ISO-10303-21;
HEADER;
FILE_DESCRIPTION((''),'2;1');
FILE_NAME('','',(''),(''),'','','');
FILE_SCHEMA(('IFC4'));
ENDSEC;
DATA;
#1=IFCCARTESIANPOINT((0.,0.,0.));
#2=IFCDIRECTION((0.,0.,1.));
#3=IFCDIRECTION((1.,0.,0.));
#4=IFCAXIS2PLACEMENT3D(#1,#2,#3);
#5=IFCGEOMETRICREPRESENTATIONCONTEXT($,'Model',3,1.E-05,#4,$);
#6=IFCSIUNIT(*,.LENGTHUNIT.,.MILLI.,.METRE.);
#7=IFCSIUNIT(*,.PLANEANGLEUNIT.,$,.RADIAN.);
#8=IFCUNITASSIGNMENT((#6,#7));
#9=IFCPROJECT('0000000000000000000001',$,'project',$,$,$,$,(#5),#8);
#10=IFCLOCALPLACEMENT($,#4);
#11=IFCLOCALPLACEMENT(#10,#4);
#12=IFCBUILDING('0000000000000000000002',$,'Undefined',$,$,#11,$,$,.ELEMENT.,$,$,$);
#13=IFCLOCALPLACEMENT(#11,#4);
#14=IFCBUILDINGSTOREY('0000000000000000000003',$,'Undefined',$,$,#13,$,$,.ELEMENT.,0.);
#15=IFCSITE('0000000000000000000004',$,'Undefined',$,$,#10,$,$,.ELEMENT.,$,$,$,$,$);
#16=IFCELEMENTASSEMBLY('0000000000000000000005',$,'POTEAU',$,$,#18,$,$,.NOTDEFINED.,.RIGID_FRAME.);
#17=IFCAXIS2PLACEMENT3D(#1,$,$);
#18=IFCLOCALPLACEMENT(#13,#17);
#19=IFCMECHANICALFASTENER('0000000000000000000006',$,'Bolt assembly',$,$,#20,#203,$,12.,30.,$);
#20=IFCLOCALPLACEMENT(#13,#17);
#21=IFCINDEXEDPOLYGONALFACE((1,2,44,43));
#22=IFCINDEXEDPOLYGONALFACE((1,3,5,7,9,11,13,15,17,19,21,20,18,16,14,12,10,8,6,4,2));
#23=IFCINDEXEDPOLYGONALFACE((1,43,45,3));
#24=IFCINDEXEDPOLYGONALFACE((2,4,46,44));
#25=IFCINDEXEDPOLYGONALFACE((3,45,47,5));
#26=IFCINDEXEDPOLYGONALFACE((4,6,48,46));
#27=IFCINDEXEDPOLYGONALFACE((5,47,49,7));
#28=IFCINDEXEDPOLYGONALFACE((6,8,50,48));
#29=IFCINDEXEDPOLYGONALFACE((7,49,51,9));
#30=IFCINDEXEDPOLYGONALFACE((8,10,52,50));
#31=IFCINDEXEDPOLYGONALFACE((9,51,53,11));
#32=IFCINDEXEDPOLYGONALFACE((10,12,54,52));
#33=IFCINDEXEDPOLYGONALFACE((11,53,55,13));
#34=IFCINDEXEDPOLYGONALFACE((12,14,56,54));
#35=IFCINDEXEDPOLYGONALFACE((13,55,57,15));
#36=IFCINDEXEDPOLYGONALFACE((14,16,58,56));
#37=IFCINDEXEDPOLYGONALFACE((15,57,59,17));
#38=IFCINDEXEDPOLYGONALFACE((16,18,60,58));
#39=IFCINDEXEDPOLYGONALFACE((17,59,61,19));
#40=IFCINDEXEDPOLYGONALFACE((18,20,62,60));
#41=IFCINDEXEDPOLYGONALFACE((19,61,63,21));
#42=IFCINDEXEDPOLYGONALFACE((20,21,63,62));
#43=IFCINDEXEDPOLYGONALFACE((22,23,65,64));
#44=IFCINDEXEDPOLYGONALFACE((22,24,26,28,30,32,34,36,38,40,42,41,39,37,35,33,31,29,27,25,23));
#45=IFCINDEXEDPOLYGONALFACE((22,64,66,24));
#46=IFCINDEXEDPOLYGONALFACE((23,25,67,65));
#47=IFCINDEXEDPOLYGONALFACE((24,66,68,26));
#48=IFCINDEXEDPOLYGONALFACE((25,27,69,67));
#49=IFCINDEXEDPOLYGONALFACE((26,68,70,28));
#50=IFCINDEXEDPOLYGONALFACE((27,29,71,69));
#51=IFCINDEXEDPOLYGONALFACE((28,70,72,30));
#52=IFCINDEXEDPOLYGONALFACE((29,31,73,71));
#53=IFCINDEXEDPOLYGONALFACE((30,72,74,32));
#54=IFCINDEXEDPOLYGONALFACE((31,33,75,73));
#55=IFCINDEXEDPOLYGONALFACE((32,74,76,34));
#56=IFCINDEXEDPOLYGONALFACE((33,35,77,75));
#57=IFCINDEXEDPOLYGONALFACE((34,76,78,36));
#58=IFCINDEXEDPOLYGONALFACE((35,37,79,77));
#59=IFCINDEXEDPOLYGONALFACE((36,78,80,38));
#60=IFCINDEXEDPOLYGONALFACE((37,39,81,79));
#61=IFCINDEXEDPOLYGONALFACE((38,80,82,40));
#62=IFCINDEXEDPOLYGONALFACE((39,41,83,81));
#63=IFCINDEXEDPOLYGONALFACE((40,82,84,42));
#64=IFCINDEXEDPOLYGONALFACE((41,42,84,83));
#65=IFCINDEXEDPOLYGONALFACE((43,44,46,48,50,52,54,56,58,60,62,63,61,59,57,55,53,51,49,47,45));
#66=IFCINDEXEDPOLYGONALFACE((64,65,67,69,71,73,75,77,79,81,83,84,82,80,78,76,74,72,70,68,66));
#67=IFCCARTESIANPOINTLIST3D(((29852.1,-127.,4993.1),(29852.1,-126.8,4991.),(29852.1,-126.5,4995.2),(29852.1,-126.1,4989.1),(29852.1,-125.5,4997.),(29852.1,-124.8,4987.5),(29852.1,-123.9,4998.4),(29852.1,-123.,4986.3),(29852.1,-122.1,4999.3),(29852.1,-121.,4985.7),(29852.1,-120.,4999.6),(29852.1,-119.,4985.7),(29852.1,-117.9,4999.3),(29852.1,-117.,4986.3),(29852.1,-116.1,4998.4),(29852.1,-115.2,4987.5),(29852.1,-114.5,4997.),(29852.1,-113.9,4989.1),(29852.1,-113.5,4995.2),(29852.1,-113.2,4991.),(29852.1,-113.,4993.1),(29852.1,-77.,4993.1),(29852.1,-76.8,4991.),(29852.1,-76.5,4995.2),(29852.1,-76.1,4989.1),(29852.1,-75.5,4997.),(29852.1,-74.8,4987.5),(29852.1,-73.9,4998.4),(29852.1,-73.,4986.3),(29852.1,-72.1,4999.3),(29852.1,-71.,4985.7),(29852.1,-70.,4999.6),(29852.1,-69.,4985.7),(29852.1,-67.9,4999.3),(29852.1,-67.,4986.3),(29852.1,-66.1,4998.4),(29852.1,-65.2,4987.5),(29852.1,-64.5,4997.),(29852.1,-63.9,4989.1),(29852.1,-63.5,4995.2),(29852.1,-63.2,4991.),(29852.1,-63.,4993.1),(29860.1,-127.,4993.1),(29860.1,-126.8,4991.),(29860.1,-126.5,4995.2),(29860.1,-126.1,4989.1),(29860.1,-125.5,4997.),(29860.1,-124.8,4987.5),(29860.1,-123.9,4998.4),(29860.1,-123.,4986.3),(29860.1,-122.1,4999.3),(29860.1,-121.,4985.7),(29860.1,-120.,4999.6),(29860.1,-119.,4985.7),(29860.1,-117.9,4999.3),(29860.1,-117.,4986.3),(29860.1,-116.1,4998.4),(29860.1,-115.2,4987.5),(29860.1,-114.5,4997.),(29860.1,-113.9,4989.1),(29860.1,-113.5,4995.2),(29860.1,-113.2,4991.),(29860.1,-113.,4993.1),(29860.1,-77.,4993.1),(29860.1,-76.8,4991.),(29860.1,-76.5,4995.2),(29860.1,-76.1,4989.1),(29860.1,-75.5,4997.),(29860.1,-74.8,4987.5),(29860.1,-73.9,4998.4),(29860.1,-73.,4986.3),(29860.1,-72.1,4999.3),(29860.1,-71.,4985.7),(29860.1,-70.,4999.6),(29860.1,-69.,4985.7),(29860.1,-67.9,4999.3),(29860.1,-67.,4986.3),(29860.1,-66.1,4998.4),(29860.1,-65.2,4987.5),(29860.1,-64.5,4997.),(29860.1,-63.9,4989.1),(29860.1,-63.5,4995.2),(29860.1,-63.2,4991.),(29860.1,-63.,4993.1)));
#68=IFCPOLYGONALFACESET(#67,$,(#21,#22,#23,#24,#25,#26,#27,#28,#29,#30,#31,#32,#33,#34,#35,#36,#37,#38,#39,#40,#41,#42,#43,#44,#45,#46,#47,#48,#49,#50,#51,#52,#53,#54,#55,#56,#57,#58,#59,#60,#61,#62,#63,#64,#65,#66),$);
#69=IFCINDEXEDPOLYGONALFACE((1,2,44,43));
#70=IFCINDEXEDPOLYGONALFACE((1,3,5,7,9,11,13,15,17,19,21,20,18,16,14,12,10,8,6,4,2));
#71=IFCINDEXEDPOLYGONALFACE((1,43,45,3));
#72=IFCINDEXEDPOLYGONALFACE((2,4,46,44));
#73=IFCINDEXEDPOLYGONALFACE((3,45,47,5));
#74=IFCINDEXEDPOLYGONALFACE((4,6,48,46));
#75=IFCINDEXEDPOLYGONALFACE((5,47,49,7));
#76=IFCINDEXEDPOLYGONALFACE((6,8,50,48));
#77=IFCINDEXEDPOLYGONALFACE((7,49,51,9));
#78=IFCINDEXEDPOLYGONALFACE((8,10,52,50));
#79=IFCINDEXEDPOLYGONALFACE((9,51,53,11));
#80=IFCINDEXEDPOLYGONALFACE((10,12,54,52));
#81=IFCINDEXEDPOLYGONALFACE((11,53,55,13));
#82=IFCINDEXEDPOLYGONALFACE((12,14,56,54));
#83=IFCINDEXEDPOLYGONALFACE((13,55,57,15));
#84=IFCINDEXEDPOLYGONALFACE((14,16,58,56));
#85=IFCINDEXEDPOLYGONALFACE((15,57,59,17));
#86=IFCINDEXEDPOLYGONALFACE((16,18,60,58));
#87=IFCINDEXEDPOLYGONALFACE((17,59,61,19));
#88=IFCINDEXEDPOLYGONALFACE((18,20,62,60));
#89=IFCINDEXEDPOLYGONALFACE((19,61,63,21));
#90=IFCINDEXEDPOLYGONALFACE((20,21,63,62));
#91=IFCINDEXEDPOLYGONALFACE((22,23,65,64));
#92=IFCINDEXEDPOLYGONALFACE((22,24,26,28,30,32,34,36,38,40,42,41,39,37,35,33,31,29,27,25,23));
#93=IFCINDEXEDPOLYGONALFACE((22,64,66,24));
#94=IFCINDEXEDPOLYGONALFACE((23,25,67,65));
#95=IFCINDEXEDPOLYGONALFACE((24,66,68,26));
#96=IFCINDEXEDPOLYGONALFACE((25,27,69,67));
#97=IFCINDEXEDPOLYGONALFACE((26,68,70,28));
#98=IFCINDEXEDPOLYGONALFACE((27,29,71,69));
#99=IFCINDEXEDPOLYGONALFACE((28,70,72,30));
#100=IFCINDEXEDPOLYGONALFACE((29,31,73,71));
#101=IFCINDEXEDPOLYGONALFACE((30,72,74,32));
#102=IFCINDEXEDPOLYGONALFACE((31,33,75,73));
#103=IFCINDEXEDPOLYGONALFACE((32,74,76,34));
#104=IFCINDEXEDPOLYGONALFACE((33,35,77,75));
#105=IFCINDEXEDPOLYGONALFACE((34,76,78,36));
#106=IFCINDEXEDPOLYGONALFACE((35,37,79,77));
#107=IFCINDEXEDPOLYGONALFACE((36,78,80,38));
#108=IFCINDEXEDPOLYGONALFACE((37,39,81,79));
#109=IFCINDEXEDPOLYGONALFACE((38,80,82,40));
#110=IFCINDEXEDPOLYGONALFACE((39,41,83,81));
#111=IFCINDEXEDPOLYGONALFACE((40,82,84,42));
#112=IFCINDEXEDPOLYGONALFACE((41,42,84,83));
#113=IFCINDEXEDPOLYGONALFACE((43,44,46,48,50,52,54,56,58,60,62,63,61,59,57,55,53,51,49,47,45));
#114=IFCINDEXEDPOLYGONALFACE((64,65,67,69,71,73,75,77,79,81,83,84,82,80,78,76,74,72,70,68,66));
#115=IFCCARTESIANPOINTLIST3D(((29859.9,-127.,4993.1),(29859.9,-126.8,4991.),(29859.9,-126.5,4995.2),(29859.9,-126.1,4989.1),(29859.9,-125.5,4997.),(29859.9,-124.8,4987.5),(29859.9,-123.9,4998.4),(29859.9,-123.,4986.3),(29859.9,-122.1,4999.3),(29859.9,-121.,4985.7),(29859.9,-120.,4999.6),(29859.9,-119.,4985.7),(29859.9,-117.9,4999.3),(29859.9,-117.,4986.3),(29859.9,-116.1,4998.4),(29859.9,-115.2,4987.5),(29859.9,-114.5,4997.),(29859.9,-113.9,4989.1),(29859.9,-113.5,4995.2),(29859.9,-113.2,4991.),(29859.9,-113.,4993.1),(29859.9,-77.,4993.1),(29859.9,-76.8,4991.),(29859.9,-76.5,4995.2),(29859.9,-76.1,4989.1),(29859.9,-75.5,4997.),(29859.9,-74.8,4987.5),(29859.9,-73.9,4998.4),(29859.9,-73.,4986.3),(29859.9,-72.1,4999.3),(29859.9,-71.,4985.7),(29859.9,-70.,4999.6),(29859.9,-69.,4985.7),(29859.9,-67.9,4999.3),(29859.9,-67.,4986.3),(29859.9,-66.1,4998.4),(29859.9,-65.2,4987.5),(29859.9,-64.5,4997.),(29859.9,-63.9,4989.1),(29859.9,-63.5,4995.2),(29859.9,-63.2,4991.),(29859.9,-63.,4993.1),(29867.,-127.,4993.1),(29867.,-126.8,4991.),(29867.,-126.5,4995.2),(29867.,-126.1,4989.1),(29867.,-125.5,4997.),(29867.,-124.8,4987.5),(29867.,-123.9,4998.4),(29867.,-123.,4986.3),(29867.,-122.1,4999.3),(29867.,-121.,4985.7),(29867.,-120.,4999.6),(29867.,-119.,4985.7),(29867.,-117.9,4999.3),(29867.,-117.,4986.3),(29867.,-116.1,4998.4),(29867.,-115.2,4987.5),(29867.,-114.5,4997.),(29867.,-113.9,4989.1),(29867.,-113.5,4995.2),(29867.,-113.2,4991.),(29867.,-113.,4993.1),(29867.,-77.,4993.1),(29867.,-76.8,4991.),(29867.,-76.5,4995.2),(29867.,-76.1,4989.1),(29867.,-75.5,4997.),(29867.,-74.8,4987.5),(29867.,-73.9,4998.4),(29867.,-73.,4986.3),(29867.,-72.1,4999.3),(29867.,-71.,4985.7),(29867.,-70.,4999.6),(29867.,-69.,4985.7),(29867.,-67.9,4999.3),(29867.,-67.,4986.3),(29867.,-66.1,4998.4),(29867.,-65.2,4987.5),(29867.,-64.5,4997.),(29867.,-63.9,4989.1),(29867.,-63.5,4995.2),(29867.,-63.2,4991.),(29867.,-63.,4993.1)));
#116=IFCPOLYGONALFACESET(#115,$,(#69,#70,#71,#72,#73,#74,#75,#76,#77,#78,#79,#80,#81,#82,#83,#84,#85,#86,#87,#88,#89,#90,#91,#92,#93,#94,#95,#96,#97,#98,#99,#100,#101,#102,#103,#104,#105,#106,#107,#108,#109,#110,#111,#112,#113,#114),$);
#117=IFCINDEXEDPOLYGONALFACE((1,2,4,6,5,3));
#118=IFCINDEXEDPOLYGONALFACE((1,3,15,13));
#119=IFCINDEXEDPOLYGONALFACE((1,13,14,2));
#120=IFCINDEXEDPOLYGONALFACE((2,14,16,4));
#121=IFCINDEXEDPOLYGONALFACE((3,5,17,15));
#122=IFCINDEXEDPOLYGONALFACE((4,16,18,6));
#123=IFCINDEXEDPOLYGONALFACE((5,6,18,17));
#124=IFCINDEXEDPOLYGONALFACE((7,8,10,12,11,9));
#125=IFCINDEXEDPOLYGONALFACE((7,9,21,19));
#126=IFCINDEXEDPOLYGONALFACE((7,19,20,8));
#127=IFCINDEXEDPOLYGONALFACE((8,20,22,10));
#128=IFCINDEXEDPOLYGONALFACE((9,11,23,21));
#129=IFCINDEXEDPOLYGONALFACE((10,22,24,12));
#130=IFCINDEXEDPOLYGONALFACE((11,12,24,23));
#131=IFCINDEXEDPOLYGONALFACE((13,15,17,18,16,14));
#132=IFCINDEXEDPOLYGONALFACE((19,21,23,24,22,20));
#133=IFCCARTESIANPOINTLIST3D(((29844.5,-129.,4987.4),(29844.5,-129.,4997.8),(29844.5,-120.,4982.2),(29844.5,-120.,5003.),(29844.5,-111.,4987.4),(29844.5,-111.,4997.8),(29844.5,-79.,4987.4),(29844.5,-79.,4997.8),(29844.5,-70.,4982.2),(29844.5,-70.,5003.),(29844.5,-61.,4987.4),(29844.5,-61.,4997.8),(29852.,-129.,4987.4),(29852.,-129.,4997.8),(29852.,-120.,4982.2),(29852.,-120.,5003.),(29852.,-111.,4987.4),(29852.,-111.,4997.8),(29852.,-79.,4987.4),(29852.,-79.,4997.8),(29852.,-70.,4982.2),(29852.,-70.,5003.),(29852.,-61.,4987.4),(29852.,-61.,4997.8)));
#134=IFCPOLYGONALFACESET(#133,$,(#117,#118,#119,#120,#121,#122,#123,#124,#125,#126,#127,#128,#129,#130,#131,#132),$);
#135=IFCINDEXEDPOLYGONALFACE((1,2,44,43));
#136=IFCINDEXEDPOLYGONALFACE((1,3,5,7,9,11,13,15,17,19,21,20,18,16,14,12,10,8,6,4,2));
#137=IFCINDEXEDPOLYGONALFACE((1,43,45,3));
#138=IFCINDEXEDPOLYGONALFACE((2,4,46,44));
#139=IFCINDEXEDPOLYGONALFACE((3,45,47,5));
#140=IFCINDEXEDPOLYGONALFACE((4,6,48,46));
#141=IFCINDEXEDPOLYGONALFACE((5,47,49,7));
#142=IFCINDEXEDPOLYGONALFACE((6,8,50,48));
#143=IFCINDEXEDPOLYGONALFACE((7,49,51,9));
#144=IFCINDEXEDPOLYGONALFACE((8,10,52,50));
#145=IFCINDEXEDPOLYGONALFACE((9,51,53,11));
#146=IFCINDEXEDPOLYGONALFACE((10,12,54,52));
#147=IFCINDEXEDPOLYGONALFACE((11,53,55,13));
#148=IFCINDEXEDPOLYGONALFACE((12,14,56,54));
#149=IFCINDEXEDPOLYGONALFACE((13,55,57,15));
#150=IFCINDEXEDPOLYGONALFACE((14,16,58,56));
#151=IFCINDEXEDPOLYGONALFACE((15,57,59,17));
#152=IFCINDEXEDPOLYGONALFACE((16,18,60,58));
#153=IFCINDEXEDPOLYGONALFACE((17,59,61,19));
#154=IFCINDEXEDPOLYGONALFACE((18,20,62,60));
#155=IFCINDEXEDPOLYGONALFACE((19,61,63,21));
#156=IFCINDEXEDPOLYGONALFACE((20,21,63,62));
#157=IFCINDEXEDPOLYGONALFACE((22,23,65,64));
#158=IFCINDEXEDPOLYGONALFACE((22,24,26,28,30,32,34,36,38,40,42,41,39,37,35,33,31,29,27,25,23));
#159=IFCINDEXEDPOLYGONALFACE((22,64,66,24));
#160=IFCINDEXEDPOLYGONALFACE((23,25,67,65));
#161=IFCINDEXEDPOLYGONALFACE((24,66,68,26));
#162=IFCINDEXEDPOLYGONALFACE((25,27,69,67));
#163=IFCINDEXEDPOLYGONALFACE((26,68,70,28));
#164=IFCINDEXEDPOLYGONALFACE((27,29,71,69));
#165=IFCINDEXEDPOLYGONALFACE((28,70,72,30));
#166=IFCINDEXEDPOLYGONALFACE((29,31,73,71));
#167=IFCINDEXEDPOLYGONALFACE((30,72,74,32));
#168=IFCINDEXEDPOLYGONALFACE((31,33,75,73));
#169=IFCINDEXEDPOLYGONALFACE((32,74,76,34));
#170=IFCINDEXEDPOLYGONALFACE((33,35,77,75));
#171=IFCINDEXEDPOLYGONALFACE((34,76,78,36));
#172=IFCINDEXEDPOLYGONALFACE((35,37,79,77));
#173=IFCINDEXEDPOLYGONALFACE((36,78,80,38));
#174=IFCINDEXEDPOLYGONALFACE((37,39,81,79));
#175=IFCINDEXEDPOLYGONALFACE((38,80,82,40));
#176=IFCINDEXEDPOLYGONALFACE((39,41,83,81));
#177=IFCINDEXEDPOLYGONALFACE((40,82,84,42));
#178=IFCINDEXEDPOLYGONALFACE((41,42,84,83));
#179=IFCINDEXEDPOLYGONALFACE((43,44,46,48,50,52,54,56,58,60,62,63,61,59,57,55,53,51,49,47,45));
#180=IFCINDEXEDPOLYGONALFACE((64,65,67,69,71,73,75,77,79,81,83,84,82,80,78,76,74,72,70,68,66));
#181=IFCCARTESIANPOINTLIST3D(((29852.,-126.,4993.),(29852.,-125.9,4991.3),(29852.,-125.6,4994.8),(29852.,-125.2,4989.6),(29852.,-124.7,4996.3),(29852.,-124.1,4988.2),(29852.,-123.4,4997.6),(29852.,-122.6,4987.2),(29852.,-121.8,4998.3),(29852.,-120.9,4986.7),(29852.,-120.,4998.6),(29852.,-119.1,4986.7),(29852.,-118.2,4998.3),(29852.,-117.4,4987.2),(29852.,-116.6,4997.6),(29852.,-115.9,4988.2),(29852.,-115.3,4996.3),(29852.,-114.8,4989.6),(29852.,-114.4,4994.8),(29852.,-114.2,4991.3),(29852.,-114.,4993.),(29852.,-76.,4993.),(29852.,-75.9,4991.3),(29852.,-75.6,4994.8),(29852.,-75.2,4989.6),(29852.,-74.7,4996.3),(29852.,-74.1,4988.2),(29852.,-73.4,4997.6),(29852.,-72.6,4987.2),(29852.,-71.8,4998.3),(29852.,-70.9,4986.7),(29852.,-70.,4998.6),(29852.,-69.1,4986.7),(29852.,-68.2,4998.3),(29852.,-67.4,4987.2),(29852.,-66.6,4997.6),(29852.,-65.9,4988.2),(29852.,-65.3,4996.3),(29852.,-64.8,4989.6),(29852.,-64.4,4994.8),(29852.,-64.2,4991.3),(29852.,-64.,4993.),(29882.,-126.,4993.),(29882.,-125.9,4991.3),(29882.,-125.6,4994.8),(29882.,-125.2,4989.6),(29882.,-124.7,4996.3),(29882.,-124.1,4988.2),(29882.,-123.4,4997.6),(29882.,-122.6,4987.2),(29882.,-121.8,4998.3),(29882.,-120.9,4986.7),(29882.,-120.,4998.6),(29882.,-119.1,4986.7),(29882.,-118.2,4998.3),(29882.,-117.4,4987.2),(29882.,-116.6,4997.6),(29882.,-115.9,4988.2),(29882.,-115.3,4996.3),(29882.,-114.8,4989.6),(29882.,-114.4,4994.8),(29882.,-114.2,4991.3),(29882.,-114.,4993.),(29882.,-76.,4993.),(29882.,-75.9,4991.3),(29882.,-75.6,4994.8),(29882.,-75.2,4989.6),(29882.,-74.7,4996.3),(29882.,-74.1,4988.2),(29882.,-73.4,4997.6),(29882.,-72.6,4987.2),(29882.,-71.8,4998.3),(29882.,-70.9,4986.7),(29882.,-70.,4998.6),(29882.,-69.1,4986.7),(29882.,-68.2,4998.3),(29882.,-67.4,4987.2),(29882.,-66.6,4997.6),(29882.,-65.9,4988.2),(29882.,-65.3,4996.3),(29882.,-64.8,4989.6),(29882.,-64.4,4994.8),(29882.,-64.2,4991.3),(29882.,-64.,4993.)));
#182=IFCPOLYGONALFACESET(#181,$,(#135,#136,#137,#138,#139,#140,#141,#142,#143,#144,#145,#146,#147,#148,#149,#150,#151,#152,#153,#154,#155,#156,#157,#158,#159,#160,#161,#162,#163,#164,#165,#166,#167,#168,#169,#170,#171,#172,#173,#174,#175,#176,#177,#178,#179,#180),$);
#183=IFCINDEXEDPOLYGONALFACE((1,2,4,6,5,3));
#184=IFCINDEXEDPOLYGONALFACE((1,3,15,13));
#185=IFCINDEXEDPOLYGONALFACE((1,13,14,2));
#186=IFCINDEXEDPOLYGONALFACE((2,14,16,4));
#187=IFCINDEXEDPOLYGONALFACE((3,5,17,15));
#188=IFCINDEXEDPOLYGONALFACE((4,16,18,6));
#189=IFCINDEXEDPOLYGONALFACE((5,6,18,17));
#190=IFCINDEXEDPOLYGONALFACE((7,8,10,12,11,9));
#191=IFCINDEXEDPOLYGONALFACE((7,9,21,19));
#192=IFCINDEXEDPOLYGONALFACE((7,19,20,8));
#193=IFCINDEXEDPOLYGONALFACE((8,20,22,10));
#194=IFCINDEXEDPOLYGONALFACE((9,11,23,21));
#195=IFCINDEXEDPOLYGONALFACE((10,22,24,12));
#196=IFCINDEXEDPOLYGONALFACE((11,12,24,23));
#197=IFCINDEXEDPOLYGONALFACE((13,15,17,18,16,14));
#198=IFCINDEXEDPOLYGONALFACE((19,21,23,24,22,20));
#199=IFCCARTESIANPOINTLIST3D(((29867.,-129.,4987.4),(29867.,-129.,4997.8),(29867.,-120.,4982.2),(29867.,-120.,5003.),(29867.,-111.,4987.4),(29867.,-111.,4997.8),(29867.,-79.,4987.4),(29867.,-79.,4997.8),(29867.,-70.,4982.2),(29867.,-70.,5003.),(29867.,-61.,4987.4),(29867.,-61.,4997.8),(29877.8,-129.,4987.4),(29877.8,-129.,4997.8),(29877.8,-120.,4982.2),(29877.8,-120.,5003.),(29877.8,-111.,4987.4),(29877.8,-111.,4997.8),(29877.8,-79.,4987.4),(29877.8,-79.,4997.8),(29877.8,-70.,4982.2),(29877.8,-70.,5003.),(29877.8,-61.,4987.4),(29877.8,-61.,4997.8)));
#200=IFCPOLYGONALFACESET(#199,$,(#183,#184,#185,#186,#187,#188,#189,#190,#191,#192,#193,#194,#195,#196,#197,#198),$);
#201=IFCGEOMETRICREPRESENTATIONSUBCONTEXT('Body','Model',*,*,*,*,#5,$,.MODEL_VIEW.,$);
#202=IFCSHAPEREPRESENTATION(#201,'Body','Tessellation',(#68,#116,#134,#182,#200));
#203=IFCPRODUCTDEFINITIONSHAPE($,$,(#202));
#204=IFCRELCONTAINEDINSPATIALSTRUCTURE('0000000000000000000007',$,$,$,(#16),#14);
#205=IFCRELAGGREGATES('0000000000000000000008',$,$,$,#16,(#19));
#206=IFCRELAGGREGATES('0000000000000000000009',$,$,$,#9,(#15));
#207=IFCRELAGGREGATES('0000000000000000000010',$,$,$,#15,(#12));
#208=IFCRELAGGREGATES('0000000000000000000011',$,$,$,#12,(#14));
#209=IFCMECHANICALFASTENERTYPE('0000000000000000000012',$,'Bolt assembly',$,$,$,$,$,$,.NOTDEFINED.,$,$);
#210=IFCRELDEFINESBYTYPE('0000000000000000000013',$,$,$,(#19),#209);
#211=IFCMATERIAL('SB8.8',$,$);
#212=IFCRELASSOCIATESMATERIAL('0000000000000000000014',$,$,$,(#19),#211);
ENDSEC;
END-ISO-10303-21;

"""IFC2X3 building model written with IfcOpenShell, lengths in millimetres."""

from ifc_helpers import new_model, si_unit, frame, origin_with_axes, origin_2d_with_axis, place, context, subcontext, project, spatial, polyline, circle, outline, extrude, source, transform, mapped, material, type_object, element, aggregate, save


model = new_model("IFC2X3")

# Units and contexts
model_context = context("Model", 3, precision=1e-05, world=origin_with_axes())
body_context = subcontext(model_context, "Body", "Model", "MODEL_VIEW")
ifc_project = project(units=[si_unit("LENGTHUNIT", "METRE", prefix="MILLI"), si_unit("PLANEANGLEUNIT", "RADIAN")], contexts=[model_context])

# Site, building, storey
site_placement = place(None, origin_with_axes())
site = spatial("IfcSite", under=ifc_project, at=site_placement, Name="Undefined", CompositionType="ELEMENT")
building_placement = place(site_placement, origin_with_axes())
building = spatial("IfcBuilding", under=site, at=building_placement, Name="Undefined", CompositionType="ELEMENT")
storey_placement = place(building_placement, origin_with_axes())
storey = spatial("IfcBuildingStorey", under=building, at=storey_placement, Name="Undefined", CompositionType="ELEMENT", Elevation=0.0)

# Element assembly
assembly_1_placement = place(storey_placement, origin_with_axes())
assembly_1 = element("IfcElementAssembly", 1, at=assembly_1_placement, inside=storey, Name="POTEAU", AssemblyPlace="NOTDEFINED", PredefinedType="RIGID_FRAME")

# Mechanical fastener
ifc_material_1 = material(Name="SB8.8")
mechanical_fastener_type = type_object("IfcMechanicalFastenerType", Name="Bolt assembly")
shared_shape_1 = source(origin_with_axes(), body_context, "Body", "SweptSolid", [
    extrude(circle(Radius=7.0, at=origin_2d_with_axis()), frame((0.0, -7.9, 0.0), z_axis=(0.0, 1.0, 0.0), x_axis=(1.0, 0.0, 0.0)), (0.0, 0.0, 1.0), 8.0),
    extrude(circle(Radius=7.0, at=origin_2d_with_axis()), frame((0.0, -0.1, 0.0), z_axis=(0.0, 1.0, 0.0), x_axis=(1.0, 0.0, 0.0)), (0.0, 0.0, 1.0), 7.1),
    extrude(outline(polyline([(10.4, 0.0), (5.2, 9.0), (-5.2, 9.0), (-10.4, 0.0), (-5.2, -9.0), (5.2, -9.0), (10.4, 0.0)])), frame((0.0, -15.5, 0.0), z_axis=(0.0, 1.0, 0.0), x_axis=(1.0, 0.0, 0.0)), (0.0, 0.0, 1.0), 7.5),
    extrude(circle(Radius=6.0, at=origin_2d_with_axis()), frame((0.0, -8.0, 0.0), z_axis=(0.0, 1.0, 0.0), x_axis=(1.0, 0.0, 0.0)), (0.0, 0.0, 1.0), 30.0),
    extrude(outline(polyline([(10.4, 0.0), (5.2, 9.0), (-5.2, 9.0), (-10.4, 0.0), (-5.2, -9.0), (5.2, -9.0), (10.4, 0.0)])), frame((0.0, 7.0, 0.0), z_axis=(0.0, 1.0, 0.0), x_axis=(1.0, 0.0, 0.0)), (0.0, 0.0, 1.0), 10.8),
])
mechanical_fastener_1_placement = place(assembly_1_placement, frame((29860.0, -95.0, 4992.6), z_axis=(0.0, 1.0, 0.0), x_axis=(0.0, 0.0, 1.0)))
mechanical_fastener_1 = element("IfcMechanicalFastener", 2, at=mechanical_fastener_1_placement, type_object=mechanical_fastener_type, material=ifc_material_1, Name="Bolt assembly", NominalDiameter=12.0, NominalLength=30.0, context=body_context, shape_type="MappedRepresentation", body=[
    mapped(shared_shape_1, transform((0.0, 0.0, -25.0))),
    mapped(shared_shape_1, transform((0.0, 0.0, 25.0))),
])
aggregate(assembly_1, [mechanical_fastener_1])

save(model, "model.ifc")
